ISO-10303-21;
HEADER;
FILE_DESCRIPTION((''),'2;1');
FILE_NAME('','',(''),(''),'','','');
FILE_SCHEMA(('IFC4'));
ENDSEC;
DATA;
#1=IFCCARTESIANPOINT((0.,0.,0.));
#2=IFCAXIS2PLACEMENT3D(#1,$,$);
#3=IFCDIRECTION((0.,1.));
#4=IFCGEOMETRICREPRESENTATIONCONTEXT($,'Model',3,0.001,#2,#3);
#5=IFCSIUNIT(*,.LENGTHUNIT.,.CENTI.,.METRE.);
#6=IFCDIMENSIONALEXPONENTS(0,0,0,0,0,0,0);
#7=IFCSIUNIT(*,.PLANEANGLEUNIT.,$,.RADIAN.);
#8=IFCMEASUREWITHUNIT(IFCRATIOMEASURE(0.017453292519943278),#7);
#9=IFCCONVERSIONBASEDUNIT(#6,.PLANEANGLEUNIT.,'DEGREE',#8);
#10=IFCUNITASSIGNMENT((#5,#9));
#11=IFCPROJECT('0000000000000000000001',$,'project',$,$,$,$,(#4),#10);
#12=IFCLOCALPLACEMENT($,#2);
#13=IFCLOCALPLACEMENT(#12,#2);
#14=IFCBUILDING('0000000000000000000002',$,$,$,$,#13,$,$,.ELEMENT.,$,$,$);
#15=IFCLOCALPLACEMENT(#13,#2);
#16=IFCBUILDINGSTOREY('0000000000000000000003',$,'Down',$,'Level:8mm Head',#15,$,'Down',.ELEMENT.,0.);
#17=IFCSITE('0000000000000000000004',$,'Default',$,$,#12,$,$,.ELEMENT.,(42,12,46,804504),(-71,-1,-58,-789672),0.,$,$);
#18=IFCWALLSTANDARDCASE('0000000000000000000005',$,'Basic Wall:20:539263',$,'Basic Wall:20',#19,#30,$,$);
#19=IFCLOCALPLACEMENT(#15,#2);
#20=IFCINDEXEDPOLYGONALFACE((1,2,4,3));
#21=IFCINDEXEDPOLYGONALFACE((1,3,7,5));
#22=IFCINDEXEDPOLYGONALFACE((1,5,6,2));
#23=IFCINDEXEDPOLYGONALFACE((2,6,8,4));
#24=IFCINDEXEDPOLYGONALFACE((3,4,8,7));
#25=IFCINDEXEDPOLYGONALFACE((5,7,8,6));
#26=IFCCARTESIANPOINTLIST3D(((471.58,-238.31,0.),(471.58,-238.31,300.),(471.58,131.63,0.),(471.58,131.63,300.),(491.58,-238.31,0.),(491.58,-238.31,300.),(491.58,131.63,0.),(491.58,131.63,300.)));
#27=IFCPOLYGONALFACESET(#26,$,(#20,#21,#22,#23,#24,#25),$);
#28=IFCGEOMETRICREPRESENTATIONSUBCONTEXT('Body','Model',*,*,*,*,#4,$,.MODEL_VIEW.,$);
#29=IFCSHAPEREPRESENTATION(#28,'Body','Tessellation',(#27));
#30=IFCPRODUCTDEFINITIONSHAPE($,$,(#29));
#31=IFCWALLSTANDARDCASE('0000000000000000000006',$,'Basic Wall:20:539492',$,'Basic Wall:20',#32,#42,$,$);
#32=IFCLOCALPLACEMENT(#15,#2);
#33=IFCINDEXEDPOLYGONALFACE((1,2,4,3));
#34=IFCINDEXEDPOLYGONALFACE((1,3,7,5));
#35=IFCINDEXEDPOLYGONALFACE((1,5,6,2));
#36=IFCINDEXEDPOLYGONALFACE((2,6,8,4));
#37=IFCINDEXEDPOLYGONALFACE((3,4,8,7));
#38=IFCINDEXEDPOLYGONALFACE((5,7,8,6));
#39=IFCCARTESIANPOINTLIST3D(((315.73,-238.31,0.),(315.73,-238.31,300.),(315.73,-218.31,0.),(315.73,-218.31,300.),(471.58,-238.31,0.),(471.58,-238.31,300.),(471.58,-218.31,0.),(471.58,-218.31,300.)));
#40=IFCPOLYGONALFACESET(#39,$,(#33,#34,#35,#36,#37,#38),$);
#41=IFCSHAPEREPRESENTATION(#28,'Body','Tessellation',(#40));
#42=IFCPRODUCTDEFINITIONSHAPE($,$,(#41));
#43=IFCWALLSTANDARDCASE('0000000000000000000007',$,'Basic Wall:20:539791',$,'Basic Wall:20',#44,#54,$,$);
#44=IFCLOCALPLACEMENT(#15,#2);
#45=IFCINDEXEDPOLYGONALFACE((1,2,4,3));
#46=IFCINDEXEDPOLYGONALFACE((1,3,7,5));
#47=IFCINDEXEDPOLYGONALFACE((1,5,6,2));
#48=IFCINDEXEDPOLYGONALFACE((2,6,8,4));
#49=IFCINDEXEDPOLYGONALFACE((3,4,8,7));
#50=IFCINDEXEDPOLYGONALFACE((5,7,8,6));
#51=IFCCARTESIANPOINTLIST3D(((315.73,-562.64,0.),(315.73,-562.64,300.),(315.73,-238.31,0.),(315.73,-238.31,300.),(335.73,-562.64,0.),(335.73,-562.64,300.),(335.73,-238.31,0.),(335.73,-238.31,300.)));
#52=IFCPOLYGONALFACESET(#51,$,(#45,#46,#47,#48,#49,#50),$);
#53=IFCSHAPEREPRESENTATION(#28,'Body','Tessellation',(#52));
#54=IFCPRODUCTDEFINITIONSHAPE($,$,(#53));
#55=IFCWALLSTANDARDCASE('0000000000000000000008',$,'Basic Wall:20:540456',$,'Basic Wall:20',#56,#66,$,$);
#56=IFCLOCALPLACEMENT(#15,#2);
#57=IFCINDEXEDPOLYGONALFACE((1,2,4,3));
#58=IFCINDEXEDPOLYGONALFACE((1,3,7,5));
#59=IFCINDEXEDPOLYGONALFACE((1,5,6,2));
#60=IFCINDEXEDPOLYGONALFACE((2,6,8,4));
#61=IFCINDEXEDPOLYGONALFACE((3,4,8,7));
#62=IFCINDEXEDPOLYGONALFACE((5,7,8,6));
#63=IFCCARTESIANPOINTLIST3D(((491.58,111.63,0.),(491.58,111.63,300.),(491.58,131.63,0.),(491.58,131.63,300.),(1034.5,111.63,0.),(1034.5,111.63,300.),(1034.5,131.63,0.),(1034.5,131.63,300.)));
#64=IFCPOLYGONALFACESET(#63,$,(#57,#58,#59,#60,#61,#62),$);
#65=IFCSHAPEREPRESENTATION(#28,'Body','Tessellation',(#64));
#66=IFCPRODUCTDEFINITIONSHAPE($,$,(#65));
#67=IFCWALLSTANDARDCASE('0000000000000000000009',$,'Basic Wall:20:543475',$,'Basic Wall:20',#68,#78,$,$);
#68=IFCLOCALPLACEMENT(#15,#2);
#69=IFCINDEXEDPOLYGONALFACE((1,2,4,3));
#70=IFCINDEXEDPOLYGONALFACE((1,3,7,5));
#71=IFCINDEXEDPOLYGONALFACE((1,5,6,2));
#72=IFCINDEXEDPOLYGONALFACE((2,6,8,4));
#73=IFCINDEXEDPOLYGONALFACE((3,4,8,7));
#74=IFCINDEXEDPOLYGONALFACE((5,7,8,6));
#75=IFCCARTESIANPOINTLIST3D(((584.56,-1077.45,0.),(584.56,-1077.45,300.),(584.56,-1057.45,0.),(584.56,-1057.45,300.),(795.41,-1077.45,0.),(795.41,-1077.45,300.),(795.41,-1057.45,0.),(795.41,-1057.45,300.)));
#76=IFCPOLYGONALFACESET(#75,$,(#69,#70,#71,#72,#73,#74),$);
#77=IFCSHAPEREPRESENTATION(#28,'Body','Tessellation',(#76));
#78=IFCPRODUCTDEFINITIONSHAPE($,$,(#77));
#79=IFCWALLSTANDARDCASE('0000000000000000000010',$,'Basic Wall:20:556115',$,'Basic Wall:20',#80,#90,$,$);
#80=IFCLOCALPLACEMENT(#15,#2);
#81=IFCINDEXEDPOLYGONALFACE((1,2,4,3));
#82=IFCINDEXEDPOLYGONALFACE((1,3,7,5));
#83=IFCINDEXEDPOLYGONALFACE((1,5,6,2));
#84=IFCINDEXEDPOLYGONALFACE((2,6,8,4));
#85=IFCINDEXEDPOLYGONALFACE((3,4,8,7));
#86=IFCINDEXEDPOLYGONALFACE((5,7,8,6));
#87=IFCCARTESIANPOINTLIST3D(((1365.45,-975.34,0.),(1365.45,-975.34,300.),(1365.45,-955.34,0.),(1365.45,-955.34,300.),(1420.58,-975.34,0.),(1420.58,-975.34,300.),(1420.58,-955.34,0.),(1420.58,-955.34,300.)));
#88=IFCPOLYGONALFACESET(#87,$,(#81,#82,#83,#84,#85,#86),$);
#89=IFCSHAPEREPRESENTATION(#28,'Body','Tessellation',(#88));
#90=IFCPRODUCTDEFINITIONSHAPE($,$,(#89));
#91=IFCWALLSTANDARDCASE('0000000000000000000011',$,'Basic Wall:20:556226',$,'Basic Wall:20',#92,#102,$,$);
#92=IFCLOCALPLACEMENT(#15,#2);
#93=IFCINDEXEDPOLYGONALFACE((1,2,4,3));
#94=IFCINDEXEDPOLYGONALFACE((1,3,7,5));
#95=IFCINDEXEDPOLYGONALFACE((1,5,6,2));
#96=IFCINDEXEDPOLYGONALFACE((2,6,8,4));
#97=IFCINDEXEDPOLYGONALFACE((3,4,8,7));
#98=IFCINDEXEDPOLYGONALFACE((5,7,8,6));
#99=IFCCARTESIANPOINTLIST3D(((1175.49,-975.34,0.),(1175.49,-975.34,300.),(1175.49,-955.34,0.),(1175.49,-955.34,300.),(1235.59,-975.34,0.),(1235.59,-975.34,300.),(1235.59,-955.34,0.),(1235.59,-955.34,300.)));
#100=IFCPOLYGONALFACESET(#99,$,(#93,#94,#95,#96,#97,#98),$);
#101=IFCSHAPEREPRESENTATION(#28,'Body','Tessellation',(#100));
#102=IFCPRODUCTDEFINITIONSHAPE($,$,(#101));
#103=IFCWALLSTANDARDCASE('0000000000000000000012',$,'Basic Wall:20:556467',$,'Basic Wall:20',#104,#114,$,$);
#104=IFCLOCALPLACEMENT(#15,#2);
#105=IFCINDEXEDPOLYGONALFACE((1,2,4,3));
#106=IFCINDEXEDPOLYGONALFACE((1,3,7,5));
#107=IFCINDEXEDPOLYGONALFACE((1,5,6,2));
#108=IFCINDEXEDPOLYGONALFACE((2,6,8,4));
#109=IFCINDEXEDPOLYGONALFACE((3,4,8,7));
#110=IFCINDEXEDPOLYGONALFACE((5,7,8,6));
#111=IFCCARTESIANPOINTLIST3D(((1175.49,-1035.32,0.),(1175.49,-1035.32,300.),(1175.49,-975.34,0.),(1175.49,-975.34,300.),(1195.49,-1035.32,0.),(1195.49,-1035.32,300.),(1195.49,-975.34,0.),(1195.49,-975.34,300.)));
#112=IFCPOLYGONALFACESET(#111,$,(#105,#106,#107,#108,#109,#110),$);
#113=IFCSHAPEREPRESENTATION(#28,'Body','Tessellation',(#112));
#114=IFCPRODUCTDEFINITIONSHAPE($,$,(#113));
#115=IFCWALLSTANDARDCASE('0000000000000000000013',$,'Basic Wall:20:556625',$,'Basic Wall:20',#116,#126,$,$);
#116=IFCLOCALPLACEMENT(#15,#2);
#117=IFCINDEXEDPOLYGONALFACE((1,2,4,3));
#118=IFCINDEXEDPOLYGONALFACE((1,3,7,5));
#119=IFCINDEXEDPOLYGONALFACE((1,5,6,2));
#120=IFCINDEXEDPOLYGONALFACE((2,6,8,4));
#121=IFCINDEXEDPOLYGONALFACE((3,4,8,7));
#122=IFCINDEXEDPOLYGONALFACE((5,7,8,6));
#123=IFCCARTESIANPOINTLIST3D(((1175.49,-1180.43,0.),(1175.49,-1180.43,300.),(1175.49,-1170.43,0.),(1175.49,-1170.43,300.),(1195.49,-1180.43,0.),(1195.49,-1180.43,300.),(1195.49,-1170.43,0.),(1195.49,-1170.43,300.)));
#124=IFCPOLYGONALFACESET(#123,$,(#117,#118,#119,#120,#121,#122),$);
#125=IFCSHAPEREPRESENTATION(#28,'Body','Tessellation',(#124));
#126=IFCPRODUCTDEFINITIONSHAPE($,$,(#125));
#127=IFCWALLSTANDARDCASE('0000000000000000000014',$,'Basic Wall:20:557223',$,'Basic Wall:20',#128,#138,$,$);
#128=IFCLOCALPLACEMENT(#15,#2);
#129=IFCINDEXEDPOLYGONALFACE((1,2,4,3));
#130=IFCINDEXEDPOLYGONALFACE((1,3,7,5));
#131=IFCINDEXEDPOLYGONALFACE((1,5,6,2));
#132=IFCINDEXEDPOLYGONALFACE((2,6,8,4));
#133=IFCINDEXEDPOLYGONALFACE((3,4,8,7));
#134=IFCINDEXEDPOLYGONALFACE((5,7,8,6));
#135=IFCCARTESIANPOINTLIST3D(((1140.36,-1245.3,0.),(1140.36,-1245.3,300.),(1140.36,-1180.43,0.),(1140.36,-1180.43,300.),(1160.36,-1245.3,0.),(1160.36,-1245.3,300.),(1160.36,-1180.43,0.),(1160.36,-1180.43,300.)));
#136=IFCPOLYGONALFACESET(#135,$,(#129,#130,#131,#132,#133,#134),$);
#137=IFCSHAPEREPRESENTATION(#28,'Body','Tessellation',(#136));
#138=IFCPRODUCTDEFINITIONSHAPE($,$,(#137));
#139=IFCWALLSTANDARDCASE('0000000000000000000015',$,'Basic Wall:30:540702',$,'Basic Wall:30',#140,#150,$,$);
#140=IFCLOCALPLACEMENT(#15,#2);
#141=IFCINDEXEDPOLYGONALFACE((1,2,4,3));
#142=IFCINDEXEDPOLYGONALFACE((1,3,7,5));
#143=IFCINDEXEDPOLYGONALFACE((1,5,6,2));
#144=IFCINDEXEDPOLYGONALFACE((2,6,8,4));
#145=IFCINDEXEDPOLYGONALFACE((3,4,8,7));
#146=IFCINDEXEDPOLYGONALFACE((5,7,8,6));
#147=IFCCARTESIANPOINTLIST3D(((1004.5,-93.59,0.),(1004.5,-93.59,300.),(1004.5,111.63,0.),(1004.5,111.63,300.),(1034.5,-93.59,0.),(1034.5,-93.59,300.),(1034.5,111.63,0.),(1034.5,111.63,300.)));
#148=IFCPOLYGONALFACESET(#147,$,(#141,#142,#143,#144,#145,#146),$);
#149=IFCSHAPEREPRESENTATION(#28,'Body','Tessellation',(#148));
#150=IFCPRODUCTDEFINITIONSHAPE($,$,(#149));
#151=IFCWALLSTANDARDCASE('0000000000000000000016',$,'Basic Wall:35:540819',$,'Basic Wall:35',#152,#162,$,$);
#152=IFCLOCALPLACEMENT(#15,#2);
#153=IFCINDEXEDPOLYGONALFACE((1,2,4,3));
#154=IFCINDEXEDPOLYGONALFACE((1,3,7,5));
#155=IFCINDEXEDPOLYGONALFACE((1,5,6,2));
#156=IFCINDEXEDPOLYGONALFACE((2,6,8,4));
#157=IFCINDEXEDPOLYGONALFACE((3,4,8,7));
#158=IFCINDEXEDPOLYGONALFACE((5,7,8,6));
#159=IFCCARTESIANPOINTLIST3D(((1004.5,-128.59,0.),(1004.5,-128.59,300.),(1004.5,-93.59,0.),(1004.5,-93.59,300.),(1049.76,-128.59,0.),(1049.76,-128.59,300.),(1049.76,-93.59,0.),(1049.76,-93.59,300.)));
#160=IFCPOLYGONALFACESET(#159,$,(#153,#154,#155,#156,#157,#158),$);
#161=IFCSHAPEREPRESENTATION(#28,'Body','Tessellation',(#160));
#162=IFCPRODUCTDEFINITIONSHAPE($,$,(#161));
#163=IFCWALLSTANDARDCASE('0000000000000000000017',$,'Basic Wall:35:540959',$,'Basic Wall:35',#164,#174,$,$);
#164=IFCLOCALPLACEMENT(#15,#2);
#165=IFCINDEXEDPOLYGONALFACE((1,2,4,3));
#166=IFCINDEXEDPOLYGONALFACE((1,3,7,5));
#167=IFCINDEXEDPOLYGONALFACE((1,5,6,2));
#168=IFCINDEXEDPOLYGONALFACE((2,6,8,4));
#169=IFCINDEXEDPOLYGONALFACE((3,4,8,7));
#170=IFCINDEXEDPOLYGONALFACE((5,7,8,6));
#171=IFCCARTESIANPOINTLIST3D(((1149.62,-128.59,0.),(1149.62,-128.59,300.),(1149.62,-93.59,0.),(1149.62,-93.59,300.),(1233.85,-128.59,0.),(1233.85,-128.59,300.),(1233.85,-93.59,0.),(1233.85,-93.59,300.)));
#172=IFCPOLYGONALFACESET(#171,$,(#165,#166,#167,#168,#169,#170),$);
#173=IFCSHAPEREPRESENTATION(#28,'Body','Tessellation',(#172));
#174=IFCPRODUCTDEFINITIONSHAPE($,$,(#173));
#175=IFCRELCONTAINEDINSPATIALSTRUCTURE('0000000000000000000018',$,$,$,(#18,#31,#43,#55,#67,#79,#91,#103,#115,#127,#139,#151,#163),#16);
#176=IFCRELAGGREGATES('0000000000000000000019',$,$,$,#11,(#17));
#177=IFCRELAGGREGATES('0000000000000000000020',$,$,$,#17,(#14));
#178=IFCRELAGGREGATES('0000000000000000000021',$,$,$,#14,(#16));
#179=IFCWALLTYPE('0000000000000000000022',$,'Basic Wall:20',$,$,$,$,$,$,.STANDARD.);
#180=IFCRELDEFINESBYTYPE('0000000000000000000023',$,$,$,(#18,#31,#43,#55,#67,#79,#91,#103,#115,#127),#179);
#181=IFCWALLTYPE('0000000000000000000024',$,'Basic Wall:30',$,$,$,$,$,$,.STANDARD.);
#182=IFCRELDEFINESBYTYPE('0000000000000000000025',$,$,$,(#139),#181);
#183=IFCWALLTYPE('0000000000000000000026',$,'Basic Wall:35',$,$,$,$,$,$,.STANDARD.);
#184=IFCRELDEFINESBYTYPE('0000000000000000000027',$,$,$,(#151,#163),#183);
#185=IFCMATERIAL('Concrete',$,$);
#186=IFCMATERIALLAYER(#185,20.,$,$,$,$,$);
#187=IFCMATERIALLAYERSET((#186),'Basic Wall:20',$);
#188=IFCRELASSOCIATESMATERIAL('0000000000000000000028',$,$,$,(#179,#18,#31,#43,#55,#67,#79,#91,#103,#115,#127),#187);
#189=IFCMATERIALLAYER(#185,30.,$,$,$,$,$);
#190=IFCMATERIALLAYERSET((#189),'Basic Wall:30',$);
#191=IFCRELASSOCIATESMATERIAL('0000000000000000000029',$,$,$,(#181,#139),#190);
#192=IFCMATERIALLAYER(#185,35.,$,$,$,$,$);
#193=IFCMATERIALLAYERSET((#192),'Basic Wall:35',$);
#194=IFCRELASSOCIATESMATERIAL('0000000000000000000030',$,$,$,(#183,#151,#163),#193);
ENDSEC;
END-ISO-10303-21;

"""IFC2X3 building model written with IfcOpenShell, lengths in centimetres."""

from ifc_helpers import new_model, entity, si_unit, converted_unit, direction, frame, frame_2d, origin, place, context, subcontext, project, spatial, rectangle, extrude, material, layer, layer_set, layer_usage, type_object, element, save


model = new_model("IFC2X3")

# Units and contexts
model_context = context("Model", 3, precision=0.001, world=origin(), true_north=direction((0.0, 1.0)))
body_context = subcontext(model_context, "Body", "Model", "MODEL_VIEW")
ifc_project = project(units=[si_unit("LENGTHUNIT", "METRE", prefix="CENTI"), converted_unit("PLANEANGLEUNIT", "DEGREE", entity("IfcRatioMeasure", 0.017453292519943278), si_unit("PLANEANGLEUNIT", "RADIAN"), dimensions=[0, 0, 0, 0, 0, 0, 0])], contexts=[model_context])

# Site, building, storey
site_placement = place(None, origin())
site = spatial("IfcSite", under=ifc_project, at=site_placement, Name="Default", CompositionType="ELEMENT", RefLatitude=(42, 12, 46, 804504), RefLongitude=(-71, -1, -58, -789672), RefElevation=0.0)
building_placement = place(site_placement, origin())
building = spatial("IfcBuilding", under=site, at=building_placement, CompositionType="ELEMENT")
storey_placement = place(building_placement, origin())
storey = spatial("IfcBuildingStorey", under=building, at=storey_placement, Name="Down", ObjectType="Level:8mm Head", LongName="Down", CompositionType="ELEMENT", Elevation=0.0)

# Walls
ifc_material = material(Name="Concrete")
ifc_layer_1 = layer(ifc_material, 20.0)
ifc_layer_set_1 = layer_set([ifc_layer_1], Name="Basic Wall:20")
ifc_layer_usage_1 = layer_usage(ifc_layer_set_1, "AXIS2", "POSITIVE", -10.0)
wall_type_1 = type_object("IfcWallType", Name="Basic Wall:20", PredefinedType="STANDARD", material=ifc_layer_set_1)
wall_1_placement = place(storey_placement, frame((481.58, 131.63, 0.0), z_axis=(0.0, 0.0, 1.0), x_axis=(0.0, -1.0, 0.0)))
element("IfcWallStandardCase", 1, at=wall_1_placement, inside=storey, type_object=wall_type_1, material=ifc_layer_usage_1, Name="Basic Wall:20:539263", ObjectType="Basic Wall:20", context=body_context, shape_type="SweptSolid", body=[
    extrude(rectangle(XDim=369.94, YDim=20.0, at=frame_2d((184.97, 0.0), x_axis=(-1.0, 0.0))), origin(), (0.0, 0.0, 1.0), 300.0),
])
ifc_layer_usage_2 = layer_usage(ifc_layer_set_1, "AXIS2", "NEGATIVE", 10.0)
wall_2_placement = place(storey_placement, frame((471.58, -228.31, 0.0), z_axis=(0.0, 0.0, 1.0), x_axis=(-1.0, 0.0, 0.0)))
element("IfcWallStandardCase", 2, at=wall_2_placement, inside=storey, type_object=wall_type_1, material=ifc_layer_usage_2, Name="Basic Wall:20:539492", ObjectType="Basic Wall:20", context=body_context, shape_type="SweptSolid", body=[
    extrude(rectangle(XDim=155.85, YDim=20.0, at=frame_2d((77.93, 0.0), x_axis=(-1.0, 0.0))), origin(), (0.0, 0.0, 1.0), 300.0),
])
ifc_layer_usage_3 = layer_usage(ifc_layer_set_1, "AXIS2", "POSITIVE", -10.0)
wall_3_placement = place(storey_placement, frame((325.73, -238.31, 0.0), z_axis=(0.0, 0.0, 1.0), x_axis=(0.0, -1.0, 0.0)))
element("IfcWallStandardCase", 3, at=wall_3_placement, inside=storey, type_object=wall_type_1, material=ifc_layer_usage_3, Name="Basic Wall:20:539791", ObjectType="Basic Wall:20", context=body_context, shape_type="SweptSolid", body=[
    extrude(rectangle(XDim=324.33, YDim=20.0, at=frame_2d((162.16, 0.0), x_axis=(-1.0, 0.0))), origin(), (0.0, 0.0, 1.0), 300.0),
])
ifc_layer_usage_4 = layer_usage(ifc_layer_set_1, "AXIS2", "NEGATIVE", 10.0)
wall_4_placement = place(storey_placement, frame((491.58, 121.63, 0.0)))
element("IfcWallStandardCase", 4, at=wall_4_placement, inside=storey, type_object=wall_type_1, material=ifc_layer_usage_4, Name="Basic Wall:20:540456", ObjectType="Basic Wall:20", context=body_context, shape_type="SweptSolid", body=[
    extrude(rectangle(XDim=542.92, YDim=20.0, at=frame_2d((271.46, 0.0), x_axis=(-1.0, 0.0))), origin(), (0.0, 0.0, 1.0), 300.0),
])
ifc_layer_usage_5 = layer_usage(ifc_layer_set_1, "AXIS2", "NEGATIVE", 10.0)
wall_5_placement = place(storey_placement, frame((584.56, -1067.45, 0.0)))
element("IfcWallStandardCase", 5, at=wall_5_placement, inside=storey, type_object=wall_type_1, material=ifc_layer_usage_5, Name="Basic Wall:20:543475", ObjectType="Basic Wall:20", context=body_context, shape_type="SweptSolid", body=[
    extrude(rectangle(XDim=210.84, YDim=20.0, at=frame_2d((105.42, 0.0), x_axis=(-1.0, 0.0))), origin(), (0.0, 0.0, 1.0), 300.0),
])
ifc_layer_usage_6 = layer_usage(ifc_layer_set_1, "AXIS2", "POSITIVE", -10.0)
wall_6_placement = place(storey_placement, frame((1420.58, -965.34, 0.0), z_axis=(0.0, 0.0, 1.0), x_axis=(-1.0, 0.0, 0.0)))
element("IfcWallStandardCase", 6, at=wall_6_placement, inside=storey, type_object=wall_type_1, material=ifc_layer_usage_6, Name="Basic Wall:20:556115", ObjectType="Basic Wall:20", context=body_context, shape_type="SweptSolid", body=[
    extrude(rectangle(XDim=55.13, YDim=20.0, at=frame_2d((27.57, 0.0), x_axis=(-1.0, 0.0))), origin(), (0.0, 0.0, 1.0), 300.0),
])
ifc_layer_usage_7 = layer_usage(ifc_layer_set_1, "AXIS2", "POSITIVE", -10.0)
wall_7_placement = place(storey_placement, frame((1235.59, -965.34, 0.0), z_axis=(0.0, 0.0, 1.0), x_axis=(-1.0, 0.0, 0.0)))
element("IfcWallStandardCase", 7, at=wall_7_placement, inside=storey, type_object=wall_type_1, material=ifc_layer_usage_7, Name="Basic Wall:20:556226", ObjectType="Basic Wall:20", context=body_context, shape_type="SweptSolid", body=[
    extrude(rectangle(XDim=60.1, YDim=20.0, at=frame_2d((30.05, 0.0), x_axis=(-1.0, 0.0))), origin(), (0.0, 0.0, 1.0), 300.0),
])
ifc_layer_usage_8 = layer_usage(ifc_layer_set_1, "AXIS2", "POSITIVE", -10.0)
wall_8_placement = place(storey_placement, frame((1185.49, -975.34, 0.0), z_axis=(0.0, 0.0, 1.0), x_axis=(0.0, -1.0, 0.0)))
element("IfcWallStandardCase", 8, at=wall_8_placement, inside=storey, type_object=wall_type_1, material=ifc_layer_usage_8, Name="Basic Wall:20:556467", ObjectType="Basic Wall:20", context=body_context, shape_type="SweptSolid", body=[
    extrude(rectangle(XDim=59.98, YDim=20.0, at=frame_2d((29.99, 0.0), x_axis=(-1.0, 0.0))), origin(), (0.0, 0.0, 1.0), 300.0),
])
ifc_layer_usage_9 = layer_usage(ifc_layer_set_1, "AXIS2", "POSITIVE", -10.0)
wall_9_placement = place(storey_placement, frame((1185.49, -1170.43, 0.0), z_axis=(0.0, 0.0, 1.0), x_axis=(0.0, -1.0, 0.0)))
element("IfcWallStandardCase", 9, at=wall_9_placement, inside=storey, type_object=wall_type_1, material=ifc_layer_usage_9, Name="Basic Wall:20:556625", ObjectType="Basic Wall:20", context=body_context, shape_type="SweptSolid", body=[
    extrude(rectangle(XDim=10.0, YDim=20.0, at=frame_2d((5.0, 0.0), x_axis=(-1.0, 0.0))), origin(), (0.0, 0.0, 1.0), 300.0),
])
ifc_layer_usage_10 = layer_usage(ifc_layer_set_1, "AXIS2", "POSITIVE", -10.0)
wall_10_placement = place(storey_placement, frame((1150.36, -1180.43, 0.0), z_axis=(0.0, 0.0, 1.0), x_axis=(0.0, -1.0, 0.0)))
element("IfcWallStandardCase", 10, at=wall_10_placement, inside=storey, type_object=wall_type_1, material=ifc_layer_usage_10, Name="Basic Wall:20:557223", ObjectType="Basic Wall:20", context=body_context, shape_type="SweptSolid", body=[
    extrude(rectangle(XDim=64.87, YDim=20.0, at=frame_2d((32.43, 0.0), x_axis=(-1.0, 0.0))), origin(), (0.0, 0.0, 1.0), 300.0),
])
ifc_layer_2 = layer(ifc_material, 30.0)
ifc_layer_set_2 = layer_set([ifc_layer_2], Name="Basic Wall:30")
ifc_layer_usage_11 = layer_usage(ifc_layer_set_2, "AXIS2", "NEGATIVE", 15.0)
wall_type_2 = type_object("IfcWallType", Name="Basic Wall:30", PredefinedType="STANDARD", material=ifc_layer_set_2)
wall_11_placement = place(storey_placement, frame((1019.5, 111.63, 0.0), z_axis=(0.0, 0.0, 1.0), x_axis=(0.0, -1.0, 0.0)))
element("IfcWallStandardCase", 11, at=wall_11_placement, inside=storey, type_object=wall_type_2, material=ifc_layer_usage_11, Name="Basic Wall:30:540702", ObjectType="Basic Wall:30", context=body_context, shape_type="SweptSolid", body=[
    extrude(rectangle(XDim=205.22, YDim=30.0, at=frame_2d((102.61, 0.0), x_axis=(-1.0, 0.0))), origin(), (0.0, 0.0, 1.0), 300.0),
])
ifc_layer_3 = layer(ifc_material, 35.0)
ifc_layer_set_3 = layer_set([ifc_layer_3], Name="Basic Wall:35")
ifc_layer_usage_12 = layer_usage(ifc_layer_set_3, "AXIS2", "POSITIVE", -17.5)
wall_type_3 = type_object("IfcWallType", Name="Basic Wall:35", PredefinedType="STANDARD", material=ifc_layer_set_3)
wall_12_placement = place(storey_placement, frame((1004.5, -111.09, 0.0)))
element("IfcWallStandardCase", 12, at=wall_12_placement, inside=storey, type_object=wall_type_3, material=ifc_layer_usage_12, Name="Basic Wall:35:540819", ObjectType="Basic Wall:35", context=body_context, shape_type="SweptSolid", body=[
    extrude(rectangle(XDim=45.26, YDim=35.0, at=frame_2d((22.63, 0.0), x_axis=(-1.0, 0.0))), origin(), (0.0, 0.0, 1.0), 300.0),
])
ifc_layer_usage_13 = layer_usage(ifc_layer_set_3, "AXIS2", "POSITIVE", -17.5)
wall_13_placement = place(storey_placement, frame((1149.62, -111.09, 0.0)))
element("IfcWallStandardCase", 13, at=wall_13_placement, inside=storey, type_object=wall_type_3, material=ifc_layer_usage_13, Name="Basic Wall:35:540959", ObjectType="Basic Wall:35", context=body_context, shape_type="SweptSolid", body=[
    extrude(rectangle(XDim=84.23, YDim=35.0, at=frame_2d((42.12, 0.0), x_axis=(-1.0, 0.0))), origin(), (0.0, 0.0, 1.0), 300.0),
])

save(model, "model.ifc")
